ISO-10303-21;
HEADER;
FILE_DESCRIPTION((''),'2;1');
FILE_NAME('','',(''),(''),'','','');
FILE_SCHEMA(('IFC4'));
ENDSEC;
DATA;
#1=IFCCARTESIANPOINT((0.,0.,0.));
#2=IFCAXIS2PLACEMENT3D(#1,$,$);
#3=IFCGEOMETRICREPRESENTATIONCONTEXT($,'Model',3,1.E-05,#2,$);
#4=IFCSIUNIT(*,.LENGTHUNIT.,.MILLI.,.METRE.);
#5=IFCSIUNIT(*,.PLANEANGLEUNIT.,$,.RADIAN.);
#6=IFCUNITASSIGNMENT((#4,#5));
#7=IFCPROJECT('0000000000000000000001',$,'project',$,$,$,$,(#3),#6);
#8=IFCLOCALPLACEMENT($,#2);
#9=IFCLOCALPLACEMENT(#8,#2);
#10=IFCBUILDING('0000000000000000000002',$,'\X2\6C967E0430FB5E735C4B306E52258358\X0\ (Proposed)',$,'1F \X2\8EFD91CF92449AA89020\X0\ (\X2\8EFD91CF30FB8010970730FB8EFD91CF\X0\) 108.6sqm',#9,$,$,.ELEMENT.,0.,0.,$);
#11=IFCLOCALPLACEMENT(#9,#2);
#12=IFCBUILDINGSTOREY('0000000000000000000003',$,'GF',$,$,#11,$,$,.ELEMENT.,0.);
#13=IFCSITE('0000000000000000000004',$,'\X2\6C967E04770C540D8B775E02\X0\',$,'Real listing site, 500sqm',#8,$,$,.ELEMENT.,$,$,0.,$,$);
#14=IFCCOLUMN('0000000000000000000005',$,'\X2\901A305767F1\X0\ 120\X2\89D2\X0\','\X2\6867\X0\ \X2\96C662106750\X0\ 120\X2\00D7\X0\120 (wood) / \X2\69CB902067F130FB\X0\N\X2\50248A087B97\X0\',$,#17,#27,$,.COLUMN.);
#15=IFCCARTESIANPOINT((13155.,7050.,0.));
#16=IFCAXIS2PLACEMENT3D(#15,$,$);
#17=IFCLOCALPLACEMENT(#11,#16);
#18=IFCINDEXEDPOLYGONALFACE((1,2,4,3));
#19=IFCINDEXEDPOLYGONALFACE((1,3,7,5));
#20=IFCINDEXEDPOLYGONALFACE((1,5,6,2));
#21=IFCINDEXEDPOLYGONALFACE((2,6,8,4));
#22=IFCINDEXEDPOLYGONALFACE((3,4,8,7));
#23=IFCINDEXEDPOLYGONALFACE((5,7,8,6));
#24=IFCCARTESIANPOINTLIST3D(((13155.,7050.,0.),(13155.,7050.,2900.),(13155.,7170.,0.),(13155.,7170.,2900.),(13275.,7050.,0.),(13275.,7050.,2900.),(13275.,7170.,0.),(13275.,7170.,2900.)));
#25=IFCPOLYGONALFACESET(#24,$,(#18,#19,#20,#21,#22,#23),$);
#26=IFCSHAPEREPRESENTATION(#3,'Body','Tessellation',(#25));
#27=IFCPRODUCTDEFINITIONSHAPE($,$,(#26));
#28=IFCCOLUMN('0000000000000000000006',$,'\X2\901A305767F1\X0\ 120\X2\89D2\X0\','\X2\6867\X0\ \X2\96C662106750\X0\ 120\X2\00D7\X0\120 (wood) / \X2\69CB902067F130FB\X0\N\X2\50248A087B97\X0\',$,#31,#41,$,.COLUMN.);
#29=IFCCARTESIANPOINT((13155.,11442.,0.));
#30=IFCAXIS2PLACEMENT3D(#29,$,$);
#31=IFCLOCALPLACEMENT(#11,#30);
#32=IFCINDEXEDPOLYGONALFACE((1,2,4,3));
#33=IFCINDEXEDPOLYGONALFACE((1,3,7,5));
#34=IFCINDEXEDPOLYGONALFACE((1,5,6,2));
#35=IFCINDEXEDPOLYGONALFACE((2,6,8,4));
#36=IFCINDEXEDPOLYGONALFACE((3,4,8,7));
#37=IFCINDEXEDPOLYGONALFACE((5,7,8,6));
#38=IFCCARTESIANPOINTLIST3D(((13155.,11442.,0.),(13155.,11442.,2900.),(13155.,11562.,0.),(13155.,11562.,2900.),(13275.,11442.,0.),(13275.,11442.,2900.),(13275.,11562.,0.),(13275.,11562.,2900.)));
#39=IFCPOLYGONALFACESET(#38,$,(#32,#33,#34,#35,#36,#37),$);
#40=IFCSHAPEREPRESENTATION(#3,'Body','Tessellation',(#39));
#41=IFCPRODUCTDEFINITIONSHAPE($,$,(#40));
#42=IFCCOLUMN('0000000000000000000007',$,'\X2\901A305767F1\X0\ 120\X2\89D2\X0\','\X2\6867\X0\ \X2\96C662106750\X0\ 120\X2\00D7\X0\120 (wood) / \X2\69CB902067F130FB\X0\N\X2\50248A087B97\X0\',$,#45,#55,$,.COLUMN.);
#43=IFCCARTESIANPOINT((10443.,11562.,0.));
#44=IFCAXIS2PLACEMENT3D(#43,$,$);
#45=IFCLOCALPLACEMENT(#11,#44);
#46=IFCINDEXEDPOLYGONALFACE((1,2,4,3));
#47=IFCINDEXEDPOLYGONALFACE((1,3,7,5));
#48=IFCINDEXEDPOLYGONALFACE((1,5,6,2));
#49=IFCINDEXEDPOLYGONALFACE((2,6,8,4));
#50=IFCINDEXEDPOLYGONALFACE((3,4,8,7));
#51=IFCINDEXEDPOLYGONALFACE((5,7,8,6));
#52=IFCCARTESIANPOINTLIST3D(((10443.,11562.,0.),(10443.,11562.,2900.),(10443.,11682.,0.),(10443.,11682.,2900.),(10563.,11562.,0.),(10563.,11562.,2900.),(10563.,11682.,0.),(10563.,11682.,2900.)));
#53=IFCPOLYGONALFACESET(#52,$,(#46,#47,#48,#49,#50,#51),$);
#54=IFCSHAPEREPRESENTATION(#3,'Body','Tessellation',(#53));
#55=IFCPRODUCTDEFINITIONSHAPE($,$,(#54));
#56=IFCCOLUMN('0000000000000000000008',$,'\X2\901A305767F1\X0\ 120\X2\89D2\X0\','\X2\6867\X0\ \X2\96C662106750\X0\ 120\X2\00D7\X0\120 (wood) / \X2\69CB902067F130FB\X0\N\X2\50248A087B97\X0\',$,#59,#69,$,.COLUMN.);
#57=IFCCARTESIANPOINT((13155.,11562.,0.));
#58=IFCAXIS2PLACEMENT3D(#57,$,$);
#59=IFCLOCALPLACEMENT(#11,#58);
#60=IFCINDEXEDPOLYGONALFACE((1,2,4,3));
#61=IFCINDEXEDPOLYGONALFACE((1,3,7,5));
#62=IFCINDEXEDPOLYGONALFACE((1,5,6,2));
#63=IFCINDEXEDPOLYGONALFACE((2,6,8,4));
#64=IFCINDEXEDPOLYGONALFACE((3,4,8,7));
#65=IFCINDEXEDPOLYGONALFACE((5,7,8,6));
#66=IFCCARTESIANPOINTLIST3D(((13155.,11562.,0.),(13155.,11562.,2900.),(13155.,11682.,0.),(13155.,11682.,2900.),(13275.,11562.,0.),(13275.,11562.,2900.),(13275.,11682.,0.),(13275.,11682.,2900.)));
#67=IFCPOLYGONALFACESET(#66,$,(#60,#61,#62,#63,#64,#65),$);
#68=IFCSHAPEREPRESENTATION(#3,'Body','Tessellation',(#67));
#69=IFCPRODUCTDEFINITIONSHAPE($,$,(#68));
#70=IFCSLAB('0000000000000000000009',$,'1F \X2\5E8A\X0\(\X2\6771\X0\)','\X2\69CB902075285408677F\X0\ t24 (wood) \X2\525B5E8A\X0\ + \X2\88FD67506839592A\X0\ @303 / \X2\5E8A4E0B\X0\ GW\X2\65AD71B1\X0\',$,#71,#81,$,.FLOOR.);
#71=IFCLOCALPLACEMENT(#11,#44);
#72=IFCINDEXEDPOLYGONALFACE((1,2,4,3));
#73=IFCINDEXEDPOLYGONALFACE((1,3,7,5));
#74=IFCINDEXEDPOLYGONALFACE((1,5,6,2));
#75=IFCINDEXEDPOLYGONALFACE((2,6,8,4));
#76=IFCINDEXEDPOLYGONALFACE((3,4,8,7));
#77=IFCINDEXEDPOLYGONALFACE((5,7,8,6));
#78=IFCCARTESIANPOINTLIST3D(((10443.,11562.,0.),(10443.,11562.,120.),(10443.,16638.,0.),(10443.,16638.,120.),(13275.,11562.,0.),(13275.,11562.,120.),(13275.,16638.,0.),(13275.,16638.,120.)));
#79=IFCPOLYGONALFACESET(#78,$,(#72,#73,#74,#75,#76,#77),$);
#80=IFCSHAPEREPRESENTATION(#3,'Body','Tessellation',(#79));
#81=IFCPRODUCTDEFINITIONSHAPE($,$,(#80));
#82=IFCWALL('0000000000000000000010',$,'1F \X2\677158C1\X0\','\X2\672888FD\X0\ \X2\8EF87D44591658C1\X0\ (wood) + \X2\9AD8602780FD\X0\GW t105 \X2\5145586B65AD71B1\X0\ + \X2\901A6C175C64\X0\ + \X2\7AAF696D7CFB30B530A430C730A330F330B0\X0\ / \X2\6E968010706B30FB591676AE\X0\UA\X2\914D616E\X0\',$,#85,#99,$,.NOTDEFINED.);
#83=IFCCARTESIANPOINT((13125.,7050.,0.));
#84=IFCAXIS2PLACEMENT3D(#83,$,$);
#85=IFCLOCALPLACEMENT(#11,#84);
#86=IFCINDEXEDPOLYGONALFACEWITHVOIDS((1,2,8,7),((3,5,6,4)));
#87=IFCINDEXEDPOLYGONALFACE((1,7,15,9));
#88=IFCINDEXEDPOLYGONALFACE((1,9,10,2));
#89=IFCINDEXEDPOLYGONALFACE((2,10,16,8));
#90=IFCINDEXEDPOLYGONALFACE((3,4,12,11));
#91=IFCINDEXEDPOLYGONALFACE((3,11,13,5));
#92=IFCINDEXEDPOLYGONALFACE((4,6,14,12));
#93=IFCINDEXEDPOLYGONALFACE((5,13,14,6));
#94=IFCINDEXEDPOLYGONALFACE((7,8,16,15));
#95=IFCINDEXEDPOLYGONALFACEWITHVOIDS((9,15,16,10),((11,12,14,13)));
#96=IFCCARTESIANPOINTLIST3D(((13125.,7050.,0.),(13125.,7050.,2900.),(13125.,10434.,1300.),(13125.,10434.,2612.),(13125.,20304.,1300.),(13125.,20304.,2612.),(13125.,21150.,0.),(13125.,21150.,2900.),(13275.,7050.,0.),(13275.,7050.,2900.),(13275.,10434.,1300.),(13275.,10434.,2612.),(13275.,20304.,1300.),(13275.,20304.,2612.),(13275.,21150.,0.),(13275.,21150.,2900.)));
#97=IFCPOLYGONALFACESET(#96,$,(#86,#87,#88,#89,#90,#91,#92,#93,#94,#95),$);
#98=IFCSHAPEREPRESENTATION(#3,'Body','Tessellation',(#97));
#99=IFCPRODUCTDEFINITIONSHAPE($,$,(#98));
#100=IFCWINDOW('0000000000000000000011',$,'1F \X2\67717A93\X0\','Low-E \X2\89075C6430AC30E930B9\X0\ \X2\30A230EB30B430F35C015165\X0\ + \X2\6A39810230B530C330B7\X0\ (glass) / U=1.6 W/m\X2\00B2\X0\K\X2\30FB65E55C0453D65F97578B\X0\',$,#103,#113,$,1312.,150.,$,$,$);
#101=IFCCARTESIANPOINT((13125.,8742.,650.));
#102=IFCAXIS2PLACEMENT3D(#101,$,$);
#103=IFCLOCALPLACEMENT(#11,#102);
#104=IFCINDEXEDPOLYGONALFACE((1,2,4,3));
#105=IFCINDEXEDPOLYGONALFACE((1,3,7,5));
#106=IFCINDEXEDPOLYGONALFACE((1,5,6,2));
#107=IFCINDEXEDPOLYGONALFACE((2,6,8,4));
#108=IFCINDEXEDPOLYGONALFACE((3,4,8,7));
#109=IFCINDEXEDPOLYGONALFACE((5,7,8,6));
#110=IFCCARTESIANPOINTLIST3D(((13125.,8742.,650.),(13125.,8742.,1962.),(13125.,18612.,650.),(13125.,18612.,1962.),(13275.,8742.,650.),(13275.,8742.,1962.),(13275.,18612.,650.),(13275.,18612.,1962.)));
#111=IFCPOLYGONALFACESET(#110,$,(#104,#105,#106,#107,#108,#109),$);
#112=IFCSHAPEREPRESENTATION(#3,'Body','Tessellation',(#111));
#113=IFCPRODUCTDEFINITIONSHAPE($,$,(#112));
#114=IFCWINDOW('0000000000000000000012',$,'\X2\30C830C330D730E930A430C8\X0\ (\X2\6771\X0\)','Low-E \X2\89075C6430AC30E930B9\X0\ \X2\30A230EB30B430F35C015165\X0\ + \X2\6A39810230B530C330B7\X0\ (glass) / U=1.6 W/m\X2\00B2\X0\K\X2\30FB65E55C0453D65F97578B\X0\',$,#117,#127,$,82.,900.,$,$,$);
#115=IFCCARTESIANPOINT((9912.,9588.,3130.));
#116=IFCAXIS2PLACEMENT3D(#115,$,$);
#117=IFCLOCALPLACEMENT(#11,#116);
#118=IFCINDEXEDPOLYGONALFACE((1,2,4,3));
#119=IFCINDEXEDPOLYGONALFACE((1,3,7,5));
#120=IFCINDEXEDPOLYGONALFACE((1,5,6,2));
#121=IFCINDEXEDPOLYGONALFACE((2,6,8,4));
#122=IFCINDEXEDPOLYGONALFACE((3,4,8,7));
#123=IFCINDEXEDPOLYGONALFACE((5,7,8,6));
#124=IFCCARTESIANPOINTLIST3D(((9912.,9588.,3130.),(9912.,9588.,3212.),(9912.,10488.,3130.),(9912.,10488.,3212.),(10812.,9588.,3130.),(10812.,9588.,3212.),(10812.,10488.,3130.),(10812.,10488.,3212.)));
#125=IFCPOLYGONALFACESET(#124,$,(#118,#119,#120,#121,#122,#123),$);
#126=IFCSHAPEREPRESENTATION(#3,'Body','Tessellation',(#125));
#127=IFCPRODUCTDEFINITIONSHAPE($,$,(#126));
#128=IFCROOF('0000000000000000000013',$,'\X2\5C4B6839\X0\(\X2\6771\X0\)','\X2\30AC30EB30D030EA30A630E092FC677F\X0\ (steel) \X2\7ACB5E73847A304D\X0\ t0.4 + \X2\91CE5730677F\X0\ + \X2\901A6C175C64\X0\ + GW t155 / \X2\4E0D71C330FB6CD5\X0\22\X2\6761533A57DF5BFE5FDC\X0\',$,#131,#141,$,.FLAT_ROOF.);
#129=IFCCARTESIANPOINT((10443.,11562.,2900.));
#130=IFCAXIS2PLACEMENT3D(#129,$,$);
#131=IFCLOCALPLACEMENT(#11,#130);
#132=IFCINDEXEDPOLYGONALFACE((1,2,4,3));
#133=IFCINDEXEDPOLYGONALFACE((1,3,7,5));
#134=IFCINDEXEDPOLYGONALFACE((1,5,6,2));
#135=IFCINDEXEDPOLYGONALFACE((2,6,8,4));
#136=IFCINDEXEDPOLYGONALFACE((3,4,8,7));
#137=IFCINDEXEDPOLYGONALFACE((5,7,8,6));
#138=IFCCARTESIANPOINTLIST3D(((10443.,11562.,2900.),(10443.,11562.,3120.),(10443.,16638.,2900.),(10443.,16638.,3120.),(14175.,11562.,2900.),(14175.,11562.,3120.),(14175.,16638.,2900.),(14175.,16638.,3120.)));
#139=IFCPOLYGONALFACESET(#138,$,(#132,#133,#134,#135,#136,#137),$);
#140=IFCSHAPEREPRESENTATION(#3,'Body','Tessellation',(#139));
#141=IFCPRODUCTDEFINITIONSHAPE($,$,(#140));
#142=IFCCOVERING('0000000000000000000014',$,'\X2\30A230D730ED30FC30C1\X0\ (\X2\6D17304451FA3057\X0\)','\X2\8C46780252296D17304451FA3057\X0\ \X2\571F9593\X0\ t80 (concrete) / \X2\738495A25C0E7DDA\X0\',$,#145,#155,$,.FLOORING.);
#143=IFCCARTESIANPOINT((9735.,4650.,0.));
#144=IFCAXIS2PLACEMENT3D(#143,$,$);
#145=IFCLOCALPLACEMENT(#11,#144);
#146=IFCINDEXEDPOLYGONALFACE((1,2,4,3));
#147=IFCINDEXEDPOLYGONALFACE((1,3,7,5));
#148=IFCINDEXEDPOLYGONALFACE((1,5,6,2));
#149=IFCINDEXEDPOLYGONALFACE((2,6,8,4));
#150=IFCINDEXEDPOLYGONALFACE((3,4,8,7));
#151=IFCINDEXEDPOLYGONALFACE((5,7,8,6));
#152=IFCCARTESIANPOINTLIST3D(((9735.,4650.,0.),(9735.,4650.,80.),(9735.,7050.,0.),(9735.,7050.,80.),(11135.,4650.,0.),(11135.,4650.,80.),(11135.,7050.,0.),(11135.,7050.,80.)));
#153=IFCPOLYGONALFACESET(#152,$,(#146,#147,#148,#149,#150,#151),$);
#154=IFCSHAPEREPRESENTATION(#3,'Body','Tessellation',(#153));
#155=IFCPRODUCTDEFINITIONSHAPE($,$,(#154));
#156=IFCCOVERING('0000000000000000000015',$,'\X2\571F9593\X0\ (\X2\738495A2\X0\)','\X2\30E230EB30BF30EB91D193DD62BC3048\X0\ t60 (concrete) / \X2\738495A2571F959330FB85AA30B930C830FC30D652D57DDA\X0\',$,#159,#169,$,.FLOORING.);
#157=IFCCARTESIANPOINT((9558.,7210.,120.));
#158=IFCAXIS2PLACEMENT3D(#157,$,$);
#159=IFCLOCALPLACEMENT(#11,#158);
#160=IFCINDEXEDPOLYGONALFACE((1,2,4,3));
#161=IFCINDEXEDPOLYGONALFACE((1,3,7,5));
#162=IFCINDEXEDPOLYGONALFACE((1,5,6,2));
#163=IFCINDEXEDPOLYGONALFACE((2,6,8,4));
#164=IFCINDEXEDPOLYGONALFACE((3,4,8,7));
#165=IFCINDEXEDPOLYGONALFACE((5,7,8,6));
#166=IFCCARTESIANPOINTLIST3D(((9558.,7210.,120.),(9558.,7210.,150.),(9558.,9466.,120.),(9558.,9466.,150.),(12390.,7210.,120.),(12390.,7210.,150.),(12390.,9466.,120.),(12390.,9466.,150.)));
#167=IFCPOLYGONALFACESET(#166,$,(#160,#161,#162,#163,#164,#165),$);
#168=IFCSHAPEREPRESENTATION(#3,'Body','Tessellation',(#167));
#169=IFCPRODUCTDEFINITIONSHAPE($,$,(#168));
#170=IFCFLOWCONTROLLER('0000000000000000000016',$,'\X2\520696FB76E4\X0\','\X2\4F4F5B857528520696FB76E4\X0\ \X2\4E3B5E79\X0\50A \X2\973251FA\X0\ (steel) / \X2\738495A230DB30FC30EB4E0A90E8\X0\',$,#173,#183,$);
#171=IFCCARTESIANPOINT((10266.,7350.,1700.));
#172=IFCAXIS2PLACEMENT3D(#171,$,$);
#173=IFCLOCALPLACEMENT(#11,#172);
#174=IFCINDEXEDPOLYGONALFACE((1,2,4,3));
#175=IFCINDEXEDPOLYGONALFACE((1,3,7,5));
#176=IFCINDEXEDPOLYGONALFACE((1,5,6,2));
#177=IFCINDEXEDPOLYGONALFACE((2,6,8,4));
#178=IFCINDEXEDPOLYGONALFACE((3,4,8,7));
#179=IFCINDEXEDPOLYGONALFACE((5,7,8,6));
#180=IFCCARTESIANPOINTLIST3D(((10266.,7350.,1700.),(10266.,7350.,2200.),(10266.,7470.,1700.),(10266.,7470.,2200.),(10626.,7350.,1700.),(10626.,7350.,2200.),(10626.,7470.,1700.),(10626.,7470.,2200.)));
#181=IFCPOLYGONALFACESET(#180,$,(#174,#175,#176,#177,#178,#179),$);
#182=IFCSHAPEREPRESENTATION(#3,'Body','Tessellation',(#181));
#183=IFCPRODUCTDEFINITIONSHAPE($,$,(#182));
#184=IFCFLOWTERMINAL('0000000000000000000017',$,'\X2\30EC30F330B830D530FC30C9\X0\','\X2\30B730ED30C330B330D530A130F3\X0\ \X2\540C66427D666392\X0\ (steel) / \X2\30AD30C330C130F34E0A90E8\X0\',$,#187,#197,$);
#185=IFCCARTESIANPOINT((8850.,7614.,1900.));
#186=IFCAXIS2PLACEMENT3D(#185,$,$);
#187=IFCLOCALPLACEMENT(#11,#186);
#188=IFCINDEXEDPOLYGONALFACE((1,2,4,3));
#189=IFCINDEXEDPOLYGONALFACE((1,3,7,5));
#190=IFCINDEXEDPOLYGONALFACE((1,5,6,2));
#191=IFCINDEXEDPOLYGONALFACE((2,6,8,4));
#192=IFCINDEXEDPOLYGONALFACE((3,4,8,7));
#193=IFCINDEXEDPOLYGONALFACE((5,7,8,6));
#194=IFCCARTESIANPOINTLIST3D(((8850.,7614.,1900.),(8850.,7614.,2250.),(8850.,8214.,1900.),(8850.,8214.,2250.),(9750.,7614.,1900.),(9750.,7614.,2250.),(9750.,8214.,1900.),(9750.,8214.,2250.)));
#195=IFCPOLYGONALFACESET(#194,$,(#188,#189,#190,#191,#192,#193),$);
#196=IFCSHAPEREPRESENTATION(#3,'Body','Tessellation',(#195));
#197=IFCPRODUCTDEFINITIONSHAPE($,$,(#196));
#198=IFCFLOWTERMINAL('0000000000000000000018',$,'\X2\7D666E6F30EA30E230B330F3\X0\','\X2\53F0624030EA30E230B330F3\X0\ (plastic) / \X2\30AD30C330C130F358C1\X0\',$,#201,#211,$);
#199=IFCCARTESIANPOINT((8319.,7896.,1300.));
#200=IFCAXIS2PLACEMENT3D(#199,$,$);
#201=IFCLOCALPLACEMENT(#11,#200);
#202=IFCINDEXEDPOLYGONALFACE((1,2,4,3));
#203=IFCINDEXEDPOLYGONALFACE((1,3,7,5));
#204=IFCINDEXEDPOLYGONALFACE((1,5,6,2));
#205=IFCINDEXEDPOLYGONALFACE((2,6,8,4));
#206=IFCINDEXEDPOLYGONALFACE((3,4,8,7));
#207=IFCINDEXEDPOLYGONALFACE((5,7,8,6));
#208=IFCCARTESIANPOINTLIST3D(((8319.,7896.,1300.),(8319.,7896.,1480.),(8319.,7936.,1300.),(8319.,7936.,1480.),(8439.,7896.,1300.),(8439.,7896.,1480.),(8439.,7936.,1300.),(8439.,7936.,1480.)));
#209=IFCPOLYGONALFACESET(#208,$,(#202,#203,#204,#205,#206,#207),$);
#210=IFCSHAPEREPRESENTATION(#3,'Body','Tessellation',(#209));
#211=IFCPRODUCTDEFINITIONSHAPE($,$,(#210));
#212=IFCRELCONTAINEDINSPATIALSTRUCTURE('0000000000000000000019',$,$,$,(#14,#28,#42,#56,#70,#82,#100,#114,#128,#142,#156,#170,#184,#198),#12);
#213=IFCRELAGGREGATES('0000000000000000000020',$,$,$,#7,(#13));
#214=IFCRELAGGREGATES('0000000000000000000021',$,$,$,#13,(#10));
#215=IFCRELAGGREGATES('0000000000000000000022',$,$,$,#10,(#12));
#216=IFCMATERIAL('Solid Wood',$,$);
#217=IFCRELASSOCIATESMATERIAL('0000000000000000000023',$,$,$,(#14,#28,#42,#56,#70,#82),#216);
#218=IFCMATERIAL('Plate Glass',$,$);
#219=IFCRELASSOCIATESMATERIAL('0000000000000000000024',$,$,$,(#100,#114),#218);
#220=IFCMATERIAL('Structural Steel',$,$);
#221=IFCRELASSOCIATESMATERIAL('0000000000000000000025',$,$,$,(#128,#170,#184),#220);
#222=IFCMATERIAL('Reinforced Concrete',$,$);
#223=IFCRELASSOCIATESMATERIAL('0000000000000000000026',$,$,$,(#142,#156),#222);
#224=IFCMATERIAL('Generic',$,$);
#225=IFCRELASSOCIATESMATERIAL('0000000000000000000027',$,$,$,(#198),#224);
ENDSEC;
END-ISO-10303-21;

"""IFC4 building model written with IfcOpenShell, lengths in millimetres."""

from ifc_helpers import new_model, si_unit, frame, frame_2d, origin, place, context, project, spatial, rectangle, extrude, material, element, fill, save


model = new_model("IFC4")

# Units and contexts
model_context = context("Model", 3, precision=1e-05, world=origin())
ifc_project = project(units=[si_unit("LENGTHUNIT", "METRE", prefix="MILLI"), si_unit("PLANEANGLEUNIT", "RADIAN")], contexts=[model_context])

# Site, building, storey
site_placement = place(None, origin())
site = spatial("IfcSite", under=ifc_project, at=site_placement, Name="沖縄県名護市", ObjectType="Real listing site, 500sqm", CompositionType="ELEMENT", RefElevation=0.0)
building_placement = place(site_placement, origin())
building = spatial("IfcBuilding", under=site, at=building_placement, Name="沖縄・平屋の別荘 (Proposed)", ObjectType="1F 軽量鉄骨造 (軽量・耐震・軽量) 108.6sqm", CompositionType="ELEMENT", ElevationOfRefHeight=0.0, ElevationOfTerrain=0.0)
storey_placement = place(building_placement, origin())
storey = spatial("IfcBuildingStorey", under=building, at=storey_placement, Name="GF", CompositionType="ELEMENT", Elevation=0.0)

# Columns
ifc_material_1 = material(Name="Solid Wood")
column_1_placement = place(storey_placement, frame((13155.0, 7050.0, 0.0)))
element("IfcColumn", 1, at=column_1_placement, inside=storey, material=ifc_material_1, Name="通し柱 120角", Description="桧 集成材 120×120 (wood) / 構造柱・N値計算", PredefinedType="COLUMN", context=model_context, shape_type="SweptSolid", body=[
    extrude(rectangle(XDim=120.0, YDim=120.0, at=frame_2d((60.0, 60.0))), frame((13155.0, 7050.0, 0.0)), (0.0, 0.0, 1.0), 2900.0),
])
column_2_placement = place(storey_placement, frame((13155.0, 11442.0, 0.0)))
element("IfcColumn", 2, at=column_2_placement, inside=storey, material=ifc_material_1, Name="通し柱 120角", Description="桧 集成材 120×120 (wood) / 構造柱・N値計算", PredefinedType="COLUMN", context=model_context, shape_type="SweptSolid", body=[
    extrude(rectangle(XDim=120.0, YDim=120.0, at=frame_2d((60.0, 60.0))), frame((13155.0, 11442.0, 0.0)), (0.0, 0.0, 1.0), 2900.0),
])
column_3_placement = place(storey_placement, frame((10443.0, 11562.0, 0.0)))
element("IfcColumn", 3, at=column_3_placement, inside=storey, material=ifc_material_1, Name="通し柱 120角", Description="桧 集成材 120×120 (wood) / 構造柱・N値計算", PredefinedType="COLUMN", context=model_context, shape_type="SweptSolid", body=[
    extrude(rectangle(XDim=120.0, YDim=120.0, at=frame_2d((60.0, 60.0))), frame((10443.0, 11562.0, 0.0)), (0.0, 0.0, 1.0), 2900.0),
])
column_4_placement = place(storey_placement, frame((13155.0, 11562.0, 0.0)))
element("IfcColumn", 4, at=column_4_placement, inside=storey, material=ifc_material_1, Name="通し柱 120角", Description="桧 集成材 120×120 (wood) / 構造柱・N値計算", PredefinedType="COLUMN", context=model_context, shape_type="SweptSolid", body=[
    extrude(rectangle(XDim=120.0, YDim=120.0, at=frame_2d((60.0, 60.0))), frame((13155.0, 11562.0, 0.0)), (0.0, 0.0, 1.0), 2900.0),
])

# Slab
slab_placement = place(storey_placement, frame((10443.0, 11562.0, 0.0)))
element("IfcSlab", 5, at=slab_placement, inside=storey, material=ifc_material_1, Name="1F 床(東)", Description="構造用合板 t24 (wood) 剛床 + 製材根太 @303 / 床下 GW断熱", PredefinedType="FLOOR", context=model_context, shape_type="SweptSolid", body=[
    extrude(rectangle(XDim=2832.0, YDim=5076.0, at=frame_2d((1416.0, 2538.0))), frame((10443.0, 11562.0, 0.0)), (0.0, 0.0, 1.0), 120.0),
])

# Wall, opening, window
wall_1_placement = place(storey_placement, frame((13125.0, 7050.0, 0.0)))
wall_1 = element("IfcWall", 6, at=wall_1_placement, inside=storey, material=ifc_material_1, Name="1F 東壁", Description="木製 軸組外壁 (wood) + 高性能GW t105 充填断熱 + 通気層 + 窯業系サイディング / 準耐火・外皮UA配慮", PredefinedType="NOTDEFINED", context=model_context, shape_type="SweptSolid", body=[
    extrude(rectangle(XDim=150.0, YDim=14100.0, at=frame_2d((75.0, 7050.0))), frame((13125.0, 7050.0, 0.0)), (0.0, 0.0, 1.0), 2900.0),
])
opening_placement = place(storey_placement, frame((13125.0, 8742.0, 650.0)))
opening = element("IfcOpeningElement", 7, at=opening_placement, cuts=wall_1, PredefinedType="NOTDEFINED", context=model_context, shape_type="SweptSolid", body=[
    extrude(rectangle(XDim=150.0, YDim=9870.0, at=frame_2d((75.0, 4935.0))), frame((13125.0, 8742.0, 650.0)), (0.0, 0.0, 1.0), 1312.0),
])
ifc_material_2 = material(Name="Plate Glass")
window_1_placement = place(storey_placement, frame((13125.0, 8742.0, 650.0)))
window_1 = element("IfcWindow", 8, at=window_1_placement, inside=storey, material=ifc_material_2, Name="1F 東窓", Description="Low-E 複層ガラス アルゴン封入 + 樹脂サッシ (glass) / U=1.6 W/m²K・日射取得型", OverallHeight=1312.0, OverallWidth=150.0, context=model_context, shape_type="SweptSolid", body=[
    extrude(rectangle(XDim=150.0, YDim=9870.0, at=frame_2d((75.0, 4935.0))), frame((13125.0, 8742.0, 650.0)), (0.0, 0.0, 1.0), 1312.0),
])
fill(opening, window_1)

# Window
window_2_placement = place(storey_placement, frame((9912.0, 9588.0, 3130.0)))
element("IfcWindow", 9, at=window_2_placement, inside=storey, material=ifc_material_2, Name="トップライト (東)", Description="Low-E 複層ガラス アルゴン封入 + 樹脂サッシ (glass) / U=1.6 W/m²K・日射取得型", OverallHeight=82.0, OverallWidth=900.0, context=model_context, shape_type="SweptSolid", body=[
    extrude(rectangle(XDim=900.0, YDim=900.0, at=frame_2d((450.0, 450.0))), frame((9912.0, 9588.0, 3130.0)), (0.0, 0.0, 1.0), 82.0),
])

# Roof
ifc_material_3 = material(Name="Structural Steel")
roof_placement = place(storey_placement, frame((10443.0, 11562.0, 2900.0)))
element("IfcRoof", 10, at=roof_placement, inside=storey, material=ifc_material_3, Name="屋根(東)", Description="ガルバリウム鋼板 (steel) 立平葺き t0.4 + 野地板 + 通気層 + GW t155 / 不燃・法22条区域対応", PredefinedType="FLAT_ROOF", context=model_context, shape_type="SweptSolid", body=[
    extrude(rectangle(XDim=3732.0, YDim=5076.0, at=frame_2d((1866.0, 2538.0))), frame((10443.0, 11562.0, 2900.0)), (0.0, 0.0, 1.0), 220.0),
])

# Coverings
ifc_material_4 = material(Name="Reinforced Concrete")
covering_1_placement = place(storey_placement, frame((9735.0, 4650.0, 0.0)))
element("IfcCovering", 11, at=covering_1_placement, inside=storey, material=ifc_material_4, Name="アプローチ (洗い出し)", Description="豆砂利洗い出し 土間 t80 (concrete) / 玄関導線", PredefinedType="FLOORING", context=model_context, shape_type="SweptSolid", body=[
    extrude(rectangle(XDim=1400.0, YDim=2400.0, at=frame_2d((700.0, 1200.0))), frame((9735.0, 4650.0, 0.0)), (0.0, 0.0, 1.0), 80.0),
])
covering_2_placement = place(storey_placement, frame((9558.0, 7210.0, 120.0)))
element("IfcCovering", 12, at=covering_2_placement, inside=storey, material=ifc_material_4, Name="土間 (玄関)", Description="モルタル金鏝押え t60 (concrete) / 玄関土間・薪ストーブ動線", PredefinedType="FLOORING", context=model_context, shape_type="SweptSolid", body=[
    extrude(rectangle(XDim=2832.0, YDim=2256.0, at=frame_2d((1416.0, 1128.0))), frame((9558.0, 7210.0, 120.0)), (0.0, 0.0, 1.0), 30.0),
])

# Flow controller
flow_controller_placement = place(storey_placement, frame((10266.0, 7350.0, 1700.0)))
element("IfcFlowController", 13, at=flow_controller_placement, inside=storey, material=ifc_material_3, Name="分電盤", Description="住宅用分電盤 主幹50A 露出 (steel) / 玄関ホール上部", context=model_context, shape_type="SweptSolid", body=[
    extrude(rectangle(XDim=360.0, YDim=120.0, at=frame_2d((180.0, 60.0))), frame((10266.0, 7350.0, 1700.0)), (0.0, 0.0, 1.0), 500.0),
])

# Flow terminals
flow_terminal_1_placement = place(storey_placement, frame((8850.0, 7614.0, 1900.0)))
element("IfcFlowTerminal", 14, at=flow_terminal_1_placement, inside=storey, material=ifc_material_3, Name="レンジフード", Description="シロッコファン 同時給排 (steel) / キッチン上部", context=model_context, shape_type="SweptSolid", body=[
    extrude(rectangle(XDim=900.0, YDim=600.0, at=frame_2d((450.0, 300.0))), frame((8850.0, 7614.0, 1900.0)), (0.0, 0.0, 1.0), 350.0),
])
ifc_material_5 = material(Name="Generic")
flow_terminal_2_placement = place(storey_placement, frame((8319.0, 7896.0, 1300.0)))
element("IfcFlowTerminal", 15, at=flow_terminal_2_placement, inside=storey, material=ifc_material_5, Name="給湯リモコン", Description="台所リモコン (plastic) / キッチン壁", context=model_context, shape_type="SweptSolid", body=[
    extrude(rectangle(XDim=120.0, YDim=40.0, at=frame_2d((60.0, 20.0))), frame((8319.0, 7896.0, 1300.0)), (0.0, 0.0, 1.0), 180.0),
])

save(model, "model.ifc")
